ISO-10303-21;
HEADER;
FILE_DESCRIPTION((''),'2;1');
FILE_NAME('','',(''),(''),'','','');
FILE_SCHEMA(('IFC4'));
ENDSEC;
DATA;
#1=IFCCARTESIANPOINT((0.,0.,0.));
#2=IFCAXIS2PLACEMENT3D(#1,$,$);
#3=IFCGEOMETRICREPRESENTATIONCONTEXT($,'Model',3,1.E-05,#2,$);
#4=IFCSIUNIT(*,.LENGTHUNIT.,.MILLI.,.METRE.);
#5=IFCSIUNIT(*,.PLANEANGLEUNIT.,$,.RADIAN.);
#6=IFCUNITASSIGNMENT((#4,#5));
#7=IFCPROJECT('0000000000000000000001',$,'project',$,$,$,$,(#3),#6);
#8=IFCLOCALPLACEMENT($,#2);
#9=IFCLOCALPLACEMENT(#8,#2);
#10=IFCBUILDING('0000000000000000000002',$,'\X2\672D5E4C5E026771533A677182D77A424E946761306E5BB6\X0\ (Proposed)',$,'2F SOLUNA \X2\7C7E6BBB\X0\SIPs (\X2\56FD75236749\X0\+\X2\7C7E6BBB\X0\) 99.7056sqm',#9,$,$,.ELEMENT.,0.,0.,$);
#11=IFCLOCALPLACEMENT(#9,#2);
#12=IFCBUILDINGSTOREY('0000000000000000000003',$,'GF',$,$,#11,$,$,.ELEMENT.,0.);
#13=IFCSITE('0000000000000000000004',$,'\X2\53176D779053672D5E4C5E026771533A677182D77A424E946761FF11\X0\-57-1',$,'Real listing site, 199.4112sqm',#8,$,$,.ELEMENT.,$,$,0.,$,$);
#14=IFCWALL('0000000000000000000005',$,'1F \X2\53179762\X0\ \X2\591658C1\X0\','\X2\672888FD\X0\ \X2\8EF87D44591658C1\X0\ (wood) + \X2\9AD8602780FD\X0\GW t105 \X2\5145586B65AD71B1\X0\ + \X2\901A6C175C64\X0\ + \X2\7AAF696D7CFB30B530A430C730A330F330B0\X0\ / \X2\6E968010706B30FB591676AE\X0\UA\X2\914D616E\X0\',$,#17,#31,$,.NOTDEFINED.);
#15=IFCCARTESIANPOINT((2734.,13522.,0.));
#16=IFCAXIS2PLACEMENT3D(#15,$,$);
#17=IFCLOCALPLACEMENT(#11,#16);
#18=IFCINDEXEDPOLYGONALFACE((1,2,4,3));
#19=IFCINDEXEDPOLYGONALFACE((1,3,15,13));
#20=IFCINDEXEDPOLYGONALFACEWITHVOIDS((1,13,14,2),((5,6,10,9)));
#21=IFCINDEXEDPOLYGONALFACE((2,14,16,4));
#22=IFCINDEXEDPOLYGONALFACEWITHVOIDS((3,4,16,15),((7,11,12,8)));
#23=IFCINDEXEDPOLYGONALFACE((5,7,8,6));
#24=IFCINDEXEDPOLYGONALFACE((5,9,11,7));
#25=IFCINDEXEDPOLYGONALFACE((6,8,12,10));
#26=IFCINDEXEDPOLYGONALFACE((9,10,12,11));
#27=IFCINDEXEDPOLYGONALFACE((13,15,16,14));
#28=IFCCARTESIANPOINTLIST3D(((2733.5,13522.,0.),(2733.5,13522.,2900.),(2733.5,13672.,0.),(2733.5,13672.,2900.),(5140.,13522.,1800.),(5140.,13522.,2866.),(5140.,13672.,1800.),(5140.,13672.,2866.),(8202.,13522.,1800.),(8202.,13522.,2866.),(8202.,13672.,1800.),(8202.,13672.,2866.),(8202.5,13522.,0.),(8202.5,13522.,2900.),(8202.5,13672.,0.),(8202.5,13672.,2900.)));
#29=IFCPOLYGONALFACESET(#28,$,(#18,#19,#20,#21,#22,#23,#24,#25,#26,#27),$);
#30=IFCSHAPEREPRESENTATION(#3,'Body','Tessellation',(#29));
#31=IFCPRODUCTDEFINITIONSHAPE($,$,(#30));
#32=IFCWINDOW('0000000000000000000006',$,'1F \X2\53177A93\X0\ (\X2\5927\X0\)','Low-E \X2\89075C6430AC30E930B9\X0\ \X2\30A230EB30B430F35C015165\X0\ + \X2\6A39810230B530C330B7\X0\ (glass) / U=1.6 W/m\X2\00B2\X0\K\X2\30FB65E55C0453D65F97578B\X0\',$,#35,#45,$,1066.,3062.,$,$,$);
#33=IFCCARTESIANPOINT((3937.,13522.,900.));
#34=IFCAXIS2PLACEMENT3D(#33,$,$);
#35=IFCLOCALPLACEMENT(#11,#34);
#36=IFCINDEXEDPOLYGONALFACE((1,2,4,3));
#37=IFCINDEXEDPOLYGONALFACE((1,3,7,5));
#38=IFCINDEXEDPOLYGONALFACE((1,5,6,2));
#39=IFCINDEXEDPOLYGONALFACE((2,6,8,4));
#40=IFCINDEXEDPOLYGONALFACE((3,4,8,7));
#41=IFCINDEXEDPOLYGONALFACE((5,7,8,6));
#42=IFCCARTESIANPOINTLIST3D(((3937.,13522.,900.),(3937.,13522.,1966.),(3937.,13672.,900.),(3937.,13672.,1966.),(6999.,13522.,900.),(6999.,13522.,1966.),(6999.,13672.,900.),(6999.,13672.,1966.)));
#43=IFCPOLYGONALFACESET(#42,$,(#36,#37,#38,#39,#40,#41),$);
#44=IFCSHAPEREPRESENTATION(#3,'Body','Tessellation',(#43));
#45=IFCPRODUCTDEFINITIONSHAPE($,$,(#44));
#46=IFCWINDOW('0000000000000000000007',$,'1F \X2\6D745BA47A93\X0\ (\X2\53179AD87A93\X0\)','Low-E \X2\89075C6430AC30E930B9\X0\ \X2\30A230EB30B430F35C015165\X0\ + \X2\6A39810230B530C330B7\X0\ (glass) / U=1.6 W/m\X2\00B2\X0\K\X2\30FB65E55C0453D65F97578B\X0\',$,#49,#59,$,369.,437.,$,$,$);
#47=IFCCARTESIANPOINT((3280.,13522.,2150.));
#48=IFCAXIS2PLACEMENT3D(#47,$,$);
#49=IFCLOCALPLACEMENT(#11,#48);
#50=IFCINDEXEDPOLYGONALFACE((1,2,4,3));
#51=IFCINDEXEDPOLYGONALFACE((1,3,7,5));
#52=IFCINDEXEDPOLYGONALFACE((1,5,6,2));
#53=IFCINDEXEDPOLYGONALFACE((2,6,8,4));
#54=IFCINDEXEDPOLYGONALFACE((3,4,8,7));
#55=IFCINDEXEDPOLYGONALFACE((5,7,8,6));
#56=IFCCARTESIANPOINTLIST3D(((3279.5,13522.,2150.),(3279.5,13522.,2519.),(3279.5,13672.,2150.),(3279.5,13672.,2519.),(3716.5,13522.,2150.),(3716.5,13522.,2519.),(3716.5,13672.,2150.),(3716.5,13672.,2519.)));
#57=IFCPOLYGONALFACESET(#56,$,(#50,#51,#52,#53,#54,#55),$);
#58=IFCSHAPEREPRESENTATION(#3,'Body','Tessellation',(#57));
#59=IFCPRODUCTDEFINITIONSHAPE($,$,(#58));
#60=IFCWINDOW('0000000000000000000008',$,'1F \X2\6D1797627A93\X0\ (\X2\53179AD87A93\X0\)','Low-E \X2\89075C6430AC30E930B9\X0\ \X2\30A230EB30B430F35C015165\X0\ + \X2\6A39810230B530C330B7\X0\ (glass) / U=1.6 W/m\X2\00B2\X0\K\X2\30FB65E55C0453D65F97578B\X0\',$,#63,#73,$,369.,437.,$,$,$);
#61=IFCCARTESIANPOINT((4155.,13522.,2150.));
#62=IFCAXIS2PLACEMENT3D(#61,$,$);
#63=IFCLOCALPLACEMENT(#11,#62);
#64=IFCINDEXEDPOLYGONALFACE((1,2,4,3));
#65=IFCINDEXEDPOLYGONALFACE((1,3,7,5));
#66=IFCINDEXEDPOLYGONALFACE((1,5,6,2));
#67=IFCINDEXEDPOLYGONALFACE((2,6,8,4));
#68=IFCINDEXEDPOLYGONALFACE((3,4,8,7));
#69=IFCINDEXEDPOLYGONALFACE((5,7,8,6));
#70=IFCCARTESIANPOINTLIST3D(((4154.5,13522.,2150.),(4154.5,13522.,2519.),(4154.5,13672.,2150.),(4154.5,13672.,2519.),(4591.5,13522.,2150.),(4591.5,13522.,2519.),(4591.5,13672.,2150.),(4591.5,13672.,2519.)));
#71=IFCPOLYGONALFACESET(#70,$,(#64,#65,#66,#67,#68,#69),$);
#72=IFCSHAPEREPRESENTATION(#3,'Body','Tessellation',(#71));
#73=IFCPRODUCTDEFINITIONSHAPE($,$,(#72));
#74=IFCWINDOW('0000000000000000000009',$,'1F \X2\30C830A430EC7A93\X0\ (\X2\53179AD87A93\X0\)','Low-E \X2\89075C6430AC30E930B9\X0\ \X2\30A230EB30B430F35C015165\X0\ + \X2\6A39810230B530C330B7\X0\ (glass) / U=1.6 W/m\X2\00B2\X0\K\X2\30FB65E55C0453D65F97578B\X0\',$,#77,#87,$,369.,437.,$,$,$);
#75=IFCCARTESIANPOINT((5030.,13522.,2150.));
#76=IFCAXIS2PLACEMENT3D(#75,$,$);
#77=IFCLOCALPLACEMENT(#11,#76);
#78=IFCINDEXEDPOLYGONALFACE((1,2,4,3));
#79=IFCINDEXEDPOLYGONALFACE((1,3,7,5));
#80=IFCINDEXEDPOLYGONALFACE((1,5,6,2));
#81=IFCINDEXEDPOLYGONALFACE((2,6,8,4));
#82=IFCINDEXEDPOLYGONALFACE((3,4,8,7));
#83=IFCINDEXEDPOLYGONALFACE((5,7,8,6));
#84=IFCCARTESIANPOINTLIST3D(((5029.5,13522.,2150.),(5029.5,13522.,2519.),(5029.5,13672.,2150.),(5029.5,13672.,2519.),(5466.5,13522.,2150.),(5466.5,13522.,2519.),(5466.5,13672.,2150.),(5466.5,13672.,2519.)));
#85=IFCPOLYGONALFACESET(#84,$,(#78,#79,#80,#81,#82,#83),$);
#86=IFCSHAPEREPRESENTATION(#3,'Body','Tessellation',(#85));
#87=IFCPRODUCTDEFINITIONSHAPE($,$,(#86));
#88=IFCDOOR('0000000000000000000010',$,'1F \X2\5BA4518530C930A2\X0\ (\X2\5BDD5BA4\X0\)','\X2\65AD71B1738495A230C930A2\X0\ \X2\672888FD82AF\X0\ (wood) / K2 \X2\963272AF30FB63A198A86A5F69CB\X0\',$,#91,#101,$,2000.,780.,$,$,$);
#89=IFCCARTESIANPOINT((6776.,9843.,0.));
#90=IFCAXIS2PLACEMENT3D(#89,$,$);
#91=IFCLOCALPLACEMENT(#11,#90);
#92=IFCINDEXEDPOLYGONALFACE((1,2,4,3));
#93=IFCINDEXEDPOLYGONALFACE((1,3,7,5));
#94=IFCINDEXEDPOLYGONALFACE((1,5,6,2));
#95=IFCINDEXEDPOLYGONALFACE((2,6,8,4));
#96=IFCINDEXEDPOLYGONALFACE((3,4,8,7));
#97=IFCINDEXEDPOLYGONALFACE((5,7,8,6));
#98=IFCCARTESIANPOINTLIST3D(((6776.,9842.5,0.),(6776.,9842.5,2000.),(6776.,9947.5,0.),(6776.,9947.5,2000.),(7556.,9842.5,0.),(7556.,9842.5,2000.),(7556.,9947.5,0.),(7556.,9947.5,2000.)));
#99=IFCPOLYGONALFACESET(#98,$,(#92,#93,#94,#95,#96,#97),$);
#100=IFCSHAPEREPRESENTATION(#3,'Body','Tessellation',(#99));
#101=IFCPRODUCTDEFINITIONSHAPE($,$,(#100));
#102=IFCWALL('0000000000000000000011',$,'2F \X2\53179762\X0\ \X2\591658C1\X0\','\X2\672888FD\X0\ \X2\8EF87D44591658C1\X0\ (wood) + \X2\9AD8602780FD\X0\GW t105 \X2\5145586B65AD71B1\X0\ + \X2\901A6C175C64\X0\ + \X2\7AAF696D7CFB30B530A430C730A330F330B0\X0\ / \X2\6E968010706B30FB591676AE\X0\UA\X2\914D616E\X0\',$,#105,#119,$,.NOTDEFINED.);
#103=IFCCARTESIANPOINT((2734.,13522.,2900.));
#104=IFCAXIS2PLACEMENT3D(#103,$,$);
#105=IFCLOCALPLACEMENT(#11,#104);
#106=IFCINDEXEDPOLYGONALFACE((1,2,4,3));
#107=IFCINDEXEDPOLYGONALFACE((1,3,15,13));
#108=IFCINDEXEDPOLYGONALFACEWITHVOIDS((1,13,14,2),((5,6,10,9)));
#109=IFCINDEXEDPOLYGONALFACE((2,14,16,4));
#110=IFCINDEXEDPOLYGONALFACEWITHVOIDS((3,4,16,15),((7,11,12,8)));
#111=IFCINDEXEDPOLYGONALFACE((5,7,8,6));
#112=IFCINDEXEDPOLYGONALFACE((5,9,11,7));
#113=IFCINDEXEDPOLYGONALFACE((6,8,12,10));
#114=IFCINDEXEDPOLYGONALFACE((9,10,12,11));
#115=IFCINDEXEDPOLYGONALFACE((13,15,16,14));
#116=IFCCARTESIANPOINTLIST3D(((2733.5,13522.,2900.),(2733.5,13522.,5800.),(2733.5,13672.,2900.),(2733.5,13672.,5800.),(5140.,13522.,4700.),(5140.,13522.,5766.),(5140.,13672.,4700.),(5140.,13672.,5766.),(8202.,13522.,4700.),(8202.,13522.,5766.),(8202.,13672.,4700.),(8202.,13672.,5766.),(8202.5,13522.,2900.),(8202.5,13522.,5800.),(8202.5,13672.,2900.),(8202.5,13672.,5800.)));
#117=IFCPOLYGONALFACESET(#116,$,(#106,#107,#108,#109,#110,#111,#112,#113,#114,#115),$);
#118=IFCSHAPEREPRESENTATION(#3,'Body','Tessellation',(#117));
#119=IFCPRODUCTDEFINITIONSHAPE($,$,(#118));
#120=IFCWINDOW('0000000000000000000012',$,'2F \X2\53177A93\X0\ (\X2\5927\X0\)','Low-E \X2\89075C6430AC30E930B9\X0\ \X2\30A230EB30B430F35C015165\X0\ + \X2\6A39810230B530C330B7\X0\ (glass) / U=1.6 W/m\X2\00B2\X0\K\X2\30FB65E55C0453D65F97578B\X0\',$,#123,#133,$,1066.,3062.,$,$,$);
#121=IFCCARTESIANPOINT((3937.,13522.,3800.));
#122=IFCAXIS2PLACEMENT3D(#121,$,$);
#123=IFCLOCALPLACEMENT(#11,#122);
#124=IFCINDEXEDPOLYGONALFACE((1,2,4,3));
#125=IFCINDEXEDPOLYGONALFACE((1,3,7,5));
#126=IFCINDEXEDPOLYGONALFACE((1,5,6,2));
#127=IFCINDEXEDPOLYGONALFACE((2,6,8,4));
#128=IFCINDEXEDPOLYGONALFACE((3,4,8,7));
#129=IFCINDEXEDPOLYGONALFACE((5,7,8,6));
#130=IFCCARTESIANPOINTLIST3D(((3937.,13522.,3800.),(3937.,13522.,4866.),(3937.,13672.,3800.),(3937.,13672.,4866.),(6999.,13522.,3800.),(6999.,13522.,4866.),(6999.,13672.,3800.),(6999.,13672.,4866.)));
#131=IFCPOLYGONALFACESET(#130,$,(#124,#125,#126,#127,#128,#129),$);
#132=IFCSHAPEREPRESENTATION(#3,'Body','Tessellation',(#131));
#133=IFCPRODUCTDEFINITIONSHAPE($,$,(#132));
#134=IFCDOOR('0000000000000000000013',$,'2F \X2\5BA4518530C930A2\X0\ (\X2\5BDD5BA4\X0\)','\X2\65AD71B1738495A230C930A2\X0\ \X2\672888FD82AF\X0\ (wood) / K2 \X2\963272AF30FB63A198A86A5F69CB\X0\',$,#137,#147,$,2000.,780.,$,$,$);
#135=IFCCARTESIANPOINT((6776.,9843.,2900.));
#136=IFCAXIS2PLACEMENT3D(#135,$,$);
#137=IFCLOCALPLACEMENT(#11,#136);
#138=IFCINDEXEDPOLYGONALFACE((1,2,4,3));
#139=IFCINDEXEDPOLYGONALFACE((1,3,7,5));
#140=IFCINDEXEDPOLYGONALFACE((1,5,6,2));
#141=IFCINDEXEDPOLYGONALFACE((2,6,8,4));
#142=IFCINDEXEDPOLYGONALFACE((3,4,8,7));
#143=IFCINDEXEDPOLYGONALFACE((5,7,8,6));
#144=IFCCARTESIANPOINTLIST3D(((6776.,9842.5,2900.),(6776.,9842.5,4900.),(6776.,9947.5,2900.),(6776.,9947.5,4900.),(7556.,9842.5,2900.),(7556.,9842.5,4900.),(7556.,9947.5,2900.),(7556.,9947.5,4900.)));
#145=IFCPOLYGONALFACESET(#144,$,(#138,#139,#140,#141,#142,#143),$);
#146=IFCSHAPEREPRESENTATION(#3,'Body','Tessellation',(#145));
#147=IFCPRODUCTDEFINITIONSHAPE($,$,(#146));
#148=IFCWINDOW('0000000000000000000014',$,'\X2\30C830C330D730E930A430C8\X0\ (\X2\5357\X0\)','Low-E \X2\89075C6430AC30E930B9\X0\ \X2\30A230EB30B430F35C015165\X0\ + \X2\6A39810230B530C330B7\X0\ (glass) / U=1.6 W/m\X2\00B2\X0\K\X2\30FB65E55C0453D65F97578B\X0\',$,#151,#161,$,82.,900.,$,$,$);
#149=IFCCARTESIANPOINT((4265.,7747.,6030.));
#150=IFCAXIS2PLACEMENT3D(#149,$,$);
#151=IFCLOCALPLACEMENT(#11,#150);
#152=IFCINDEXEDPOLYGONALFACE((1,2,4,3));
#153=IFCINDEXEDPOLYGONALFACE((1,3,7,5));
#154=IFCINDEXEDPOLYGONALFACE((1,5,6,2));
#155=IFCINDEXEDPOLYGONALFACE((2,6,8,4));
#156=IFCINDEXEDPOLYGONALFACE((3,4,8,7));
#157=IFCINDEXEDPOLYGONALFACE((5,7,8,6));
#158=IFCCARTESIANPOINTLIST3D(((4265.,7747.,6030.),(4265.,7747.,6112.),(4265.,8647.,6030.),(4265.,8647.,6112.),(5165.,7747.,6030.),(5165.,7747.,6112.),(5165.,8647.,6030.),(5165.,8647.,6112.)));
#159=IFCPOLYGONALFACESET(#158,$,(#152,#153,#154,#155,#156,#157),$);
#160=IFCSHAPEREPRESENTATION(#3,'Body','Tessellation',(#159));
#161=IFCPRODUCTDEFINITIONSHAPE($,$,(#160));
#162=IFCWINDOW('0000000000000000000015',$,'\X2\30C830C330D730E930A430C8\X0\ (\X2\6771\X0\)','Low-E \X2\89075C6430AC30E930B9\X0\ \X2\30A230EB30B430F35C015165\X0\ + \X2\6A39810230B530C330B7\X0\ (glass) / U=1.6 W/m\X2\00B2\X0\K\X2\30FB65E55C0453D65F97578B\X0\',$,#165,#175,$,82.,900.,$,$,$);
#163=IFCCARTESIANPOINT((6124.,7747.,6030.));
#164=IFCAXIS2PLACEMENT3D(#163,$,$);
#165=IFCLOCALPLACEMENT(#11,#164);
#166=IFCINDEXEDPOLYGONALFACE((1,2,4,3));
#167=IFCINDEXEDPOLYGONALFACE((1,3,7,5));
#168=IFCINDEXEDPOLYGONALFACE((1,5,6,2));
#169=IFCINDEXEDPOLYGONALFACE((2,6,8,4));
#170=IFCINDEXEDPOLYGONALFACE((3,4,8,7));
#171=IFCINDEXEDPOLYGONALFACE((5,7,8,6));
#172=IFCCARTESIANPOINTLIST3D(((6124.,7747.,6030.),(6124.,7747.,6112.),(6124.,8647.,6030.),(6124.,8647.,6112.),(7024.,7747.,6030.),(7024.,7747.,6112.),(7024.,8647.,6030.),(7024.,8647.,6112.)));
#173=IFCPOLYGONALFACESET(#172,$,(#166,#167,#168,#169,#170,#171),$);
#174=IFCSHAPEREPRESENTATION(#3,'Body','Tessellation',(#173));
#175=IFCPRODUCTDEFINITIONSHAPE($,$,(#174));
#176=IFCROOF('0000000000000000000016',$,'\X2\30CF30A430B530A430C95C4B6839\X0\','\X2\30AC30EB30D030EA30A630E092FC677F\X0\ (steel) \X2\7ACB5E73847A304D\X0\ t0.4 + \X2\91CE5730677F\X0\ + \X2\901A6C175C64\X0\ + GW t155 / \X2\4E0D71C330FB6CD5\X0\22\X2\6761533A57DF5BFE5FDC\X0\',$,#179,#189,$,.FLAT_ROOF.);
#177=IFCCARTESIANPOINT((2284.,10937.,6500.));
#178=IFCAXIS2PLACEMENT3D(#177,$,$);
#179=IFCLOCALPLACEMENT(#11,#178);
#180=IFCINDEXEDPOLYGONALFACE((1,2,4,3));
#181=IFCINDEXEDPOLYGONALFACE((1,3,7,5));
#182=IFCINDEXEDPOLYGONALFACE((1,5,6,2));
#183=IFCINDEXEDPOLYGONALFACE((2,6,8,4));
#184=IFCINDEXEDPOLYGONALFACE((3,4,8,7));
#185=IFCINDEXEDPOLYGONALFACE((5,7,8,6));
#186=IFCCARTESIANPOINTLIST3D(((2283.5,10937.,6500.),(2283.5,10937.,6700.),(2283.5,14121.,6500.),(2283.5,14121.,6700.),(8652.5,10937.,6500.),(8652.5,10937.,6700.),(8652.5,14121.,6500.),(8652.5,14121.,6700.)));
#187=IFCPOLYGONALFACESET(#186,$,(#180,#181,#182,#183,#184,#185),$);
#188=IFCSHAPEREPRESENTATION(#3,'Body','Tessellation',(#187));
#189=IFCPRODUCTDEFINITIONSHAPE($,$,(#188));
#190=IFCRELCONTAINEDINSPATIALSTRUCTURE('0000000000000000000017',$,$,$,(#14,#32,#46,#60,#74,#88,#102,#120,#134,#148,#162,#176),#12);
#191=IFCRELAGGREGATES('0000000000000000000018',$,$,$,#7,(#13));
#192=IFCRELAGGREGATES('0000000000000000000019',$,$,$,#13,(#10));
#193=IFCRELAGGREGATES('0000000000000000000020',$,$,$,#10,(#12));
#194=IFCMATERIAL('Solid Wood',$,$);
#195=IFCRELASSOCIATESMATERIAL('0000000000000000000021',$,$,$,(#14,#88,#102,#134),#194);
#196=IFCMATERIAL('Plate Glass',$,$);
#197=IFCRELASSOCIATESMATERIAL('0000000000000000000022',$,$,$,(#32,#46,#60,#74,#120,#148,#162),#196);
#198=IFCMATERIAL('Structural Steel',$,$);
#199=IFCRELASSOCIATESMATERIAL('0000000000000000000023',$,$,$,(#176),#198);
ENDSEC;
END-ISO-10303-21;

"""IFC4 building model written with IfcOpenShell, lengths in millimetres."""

from ifc_helpers import new_model, si_unit, frame, frame_2d, origin, place, context, project, spatial, rectangle, extrude, material, element, fill, save


model = new_model("IFC4")

# Units and contexts
model_context = context("Model", 3, precision=1e-05, world=origin())
ifc_project = project(units=[si_unit("LENGTHUNIT", "METRE", prefix="MILLI"), si_unit("PLANEANGLEUNIT", "RADIAN")], contexts=[model_context])

# Site, building, storey
site_placement = place(None, origin())
site = spatial("IfcSite", under=ifc_project, at=site_placement, Name="北海道札幌市東区東苗穂五条１-57-1", ObjectType="Real listing site, 199.4112sqm", CompositionType="ELEMENT", RefElevation=0.0)
building_placement = place(site_placement, origin())
building = spatial("IfcBuilding", under=site, at=building_placement, Name="札幌市東区東苗穂五条の家 (Proposed)", ObjectType="2F SOLUNA 籾殻SIPs (国産杉+籾殻) 99.7056sqm", CompositionType="ELEMENT", ElevationOfRefHeight=0.0, ElevationOfTerrain=0.0)
storey_placement = place(building_placement, origin())
storey = spatial("IfcBuildingStorey", under=building, at=storey_placement, Name="GF", CompositionType="ELEMENT", Elevation=0.0)

# Wall, openings, windows
ifc_material_1 = material(Name="Solid Wood")
wall_1_placement = place(storey_placement, frame((2734.0, 13522.0, 0.0)))
wall_1 = element("IfcWall", 1, at=wall_1_placement, inside=storey, material=ifc_material_1, Name="1F 北面 外壁", Description="木製 軸組外壁 (wood) + 高性能GW t105 充填断熱 + 通気層 + 窯業系サイディング / 準耐火・外皮UA配慮", PredefinedType="NOTDEFINED", context=model_context, shape_type="SweptSolid", body=[
    extrude(rectangle(XDim=5469.0, YDim=150.0, at=frame_2d((2734.0, 75.0))), frame((2734.0, 13522.0, 0.0)), (0.0, 0.0, 1.0), 2900.0),
])
opening_1_placement = place(storey_placement, frame((3937.0, 13522.0, 900.0)))
opening_1 = element("IfcOpeningElement", 2, at=opening_1_placement, cuts=wall_1, PredefinedType="NOTDEFINED", context=model_context, shape_type="SweptSolid", body=[
    extrude(rectangle(XDim=3062.0, YDim=150.0, at=frame_2d((1531.0, 75.0))), frame((3937.0, 13522.0, 900.0)), (0.0, 0.0, 1.0), 1066.0),
])
opening_2_placement = place(storey_placement, frame((3280.0, 13522.0, 2150.0)))
opening_2 = element("IfcOpeningElement", 3, at=opening_2_placement, cuts=wall_1, PredefinedType="NOTDEFINED", context=model_context, shape_type="SweptSolid", body=[
    extrude(rectangle(XDim=437.0, YDim=150.0, at=frame_2d((218.0, 75.0))), frame((3280.0, 13522.0, 2150.0)), (0.0, 0.0, 1.0), 369.0),
])
opening_3_placement = place(storey_placement, frame((4155.0, 13522.0, 2150.0)))
opening_3 = element("IfcOpeningElement", 4, at=opening_3_placement, cuts=wall_1, PredefinedType="NOTDEFINED", context=model_context, shape_type="SweptSolid", body=[
    extrude(rectangle(XDim=437.0, YDim=150.0, at=frame_2d((218.0, 75.0))), frame((4155.0, 13522.0, 2150.0)), (0.0, 0.0, 1.0), 369.0),
])
opening_4_placement = place(storey_placement, frame((5030.0, 13522.0, 2150.0)))
opening_4 = element("IfcOpeningElement", 5, at=opening_4_placement, cuts=wall_1, PredefinedType="NOTDEFINED", context=model_context, shape_type="SweptSolid", body=[
    extrude(rectangle(XDim=437.0, YDim=150.0, at=frame_2d((218.0, 75.0))), frame((5030.0, 13522.0, 2150.0)), (0.0, 0.0, 1.0), 369.0),
])
ifc_material_2 = material(Name="Plate Glass")
window_1_placement = place(storey_placement, frame((3937.0, 13522.0, 900.0)))
window_1 = element("IfcWindow", 6, at=window_1_placement, inside=storey, material=ifc_material_2, Name="1F 北窓 (大)", Description="Low-E 複層ガラス アルゴン封入 + 樹脂サッシ (glass) / U=1.6 W/m²K・日射取得型", OverallHeight=1066.0, OverallWidth=3062.0, context=model_context, shape_type="SweptSolid", body=[
    extrude(rectangle(XDim=3062.0, YDim=150.0, at=frame_2d((1531.0, 75.0))), frame((3937.0, 13522.0, 900.0)), (0.0, 0.0, 1.0), 1066.0),
])
fill(opening_1, window_1)
window_2_placement = place(storey_placement, frame((3280.0, 13522.0, 2150.0)))
window_2 = element("IfcWindow", 7, at=window_2_placement, inside=storey, material=ifc_material_2, Name="1F 浴室窓 (北高窓)", Description="Low-E 複層ガラス アルゴン封入 + 樹脂サッシ (glass) / U=1.6 W/m²K・日射取得型", OverallHeight=369.0, OverallWidth=437.0, context=model_context, shape_type="SweptSolid", body=[
    extrude(rectangle(XDim=437.0, YDim=150.0, at=frame_2d((218.0, 75.0))), frame((3280.0, 13522.0, 2150.0)), (0.0, 0.0, 1.0), 369.0),
])
fill(opening_2, window_2)
window_3_placement = place(storey_placement, frame((4155.0, 13522.0, 2150.0)))
window_3 = element("IfcWindow", 8, at=window_3_placement, inside=storey, material=ifc_material_2, Name="1F 洗面窓 (北高窓)", Description="Low-E 複層ガラス アルゴン封入 + 樹脂サッシ (glass) / U=1.6 W/m²K・日射取得型", OverallHeight=369.0, OverallWidth=437.0, context=model_context, shape_type="SweptSolid", body=[
    extrude(rectangle(XDim=437.0, YDim=150.0, at=frame_2d((218.0, 75.0))), frame((4155.0, 13522.0, 2150.0)), (0.0, 0.0, 1.0), 369.0),
])
fill(opening_3, window_3)
window_4_placement = place(storey_placement, frame((5030.0, 13522.0, 2150.0)))
window_4 = element("IfcWindow", 9, at=window_4_placement, inside=storey, material=ifc_material_2, Name="1F トイレ窓 (北高窓)", Description="Low-E 複層ガラス アルゴン封入 + 樹脂サッシ (glass) / U=1.6 W/m²K・日射取得型", OverallHeight=369.0, OverallWidth=437.0, context=model_context, shape_type="SweptSolid", body=[
    extrude(rectangle(XDim=437.0, YDim=150.0, at=frame_2d((218.0, 75.0))), frame((5030.0, 13522.0, 2150.0)), (0.0, 0.0, 1.0), 369.0),
])
fill(opening_4, window_4)

# Door
door_1_placement = place(storey_placement, frame((6776.0, 9843.0, 0.0)))
element("IfcDoor", 10, at=door_1_placement, inside=storey, material=ifc_material_1, Name="1F 室内ドア (寝室)", Description="断熱玄関ドア 木製芯 (wood) / K2 防犯・採風機構", OverallHeight=2000.0, OverallWidth=780.0, context=model_context, shape_type="SweptSolid", body=[
    extrude(rectangle(XDim=780.0, YDim=105.0, at=frame_2d((390.0, 52.0))), frame((6776.0, 9843.0, 0.0)), (0.0, 0.0, 1.0), 2000.0),
])

# Wall, opening, window
wall_2_placement = place(storey_placement, frame((2734.0, 13522.0, 2900.0)))
wall_2 = element("IfcWall", 11, at=wall_2_placement, inside=storey, material=ifc_material_1, Name="2F 北面 外壁", Description="木製 軸組外壁 (wood) + 高性能GW t105 充填断熱 + 通気層 + 窯業系サイディング / 準耐火・外皮UA配慮", PredefinedType="NOTDEFINED", context=model_context, shape_type="SweptSolid", body=[
    extrude(rectangle(XDim=5469.0, YDim=150.0, at=frame_2d((2734.0, 75.0))), frame((2734.0, 13522.0, 2900.0)), (0.0, 0.0, 1.0), 2900.0),
])
opening_5_placement = place(storey_placement, frame((3937.0, 13522.0, 3800.0)))
opening_5 = element("IfcOpeningElement", 12, at=opening_5_placement, cuts=wall_2, PredefinedType="NOTDEFINED", context=model_context, shape_type="SweptSolid", body=[
    extrude(rectangle(XDim=3062.0, YDim=150.0, at=frame_2d((1531.0, 75.0))), frame((3937.0, 13522.0, 3800.0)), (0.0, 0.0, 1.0), 1066.0),
])
window_5_placement = place(storey_placement, frame((3937.0, 13522.0, 3800.0)))
window_5 = element("IfcWindow", 13, at=window_5_placement, inside=storey, material=ifc_material_2, Name="2F 北窓 (大)", Description="Low-E 複層ガラス アルゴン封入 + 樹脂サッシ (glass) / U=1.6 W/m²K・日射取得型", OverallHeight=1066.0, OverallWidth=3062.0, context=model_context, shape_type="SweptSolid", body=[
    extrude(rectangle(XDim=3062.0, YDim=150.0, at=frame_2d((1531.0, 75.0))), frame((3937.0, 13522.0, 3800.0)), (0.0, 0.0, 1.0), 1066.0),
])
fill(opening_5, window_5)

# Door
door_2_placement = place(storey_placement, frame((6776.0, 9843.0, 2900.0)))
element("IfcDoor", 14, at=door_2_placement, inside=storey, material=ifc_material_1, Name="2F 室内ドア (寝室)", Description="断熱玄関ドア 木製芯 (wood) / K2 防犯・採風機構", OverallHeight=2000.0, OverallWidth=780.0, context=model_context, shape_type="SweptSolid", body=[
    extrude(rectangle(XDim=780.0, YDim=105.0, at=frame_2d((390.0, 52.0))), frame((6776.0, 9843.0, 2900.0)), (0.0, 0.0, 1.0), 2000.0),
])

# Windows
window_6_placement = place(storey_placement, frame((4265.0, 7747.0, 6030.0)))
element("IfcWindow", 15, at=window_6_placement, inside=storey, material=ifc_material_2, Name="トップライト (南)", Description="Low-E 複層ガラス アルゴン封入 + 樹脂サッシ (glass) / U=1.6 W/m²K・日射取得型", OverallHeight=82.0, OverallWidth=900.0, context=model_context, shape_type="SweptSolid", body=[
    extrude(rectangle(XDim=900.0, YDim=900.0, at=frame_2d((450.0, 450.0))), frame((4265.0, 7747.0, 6030.0)), (0.0, 0.0, 1.0), 82.0),
])
window_7_placement = place(storey_placement, frame((6124.0, 7747.0, 6030.0)))
element("IfcWindow", 16, at=window_7_placement, inside=storey, material=ifc_material_2, Name="トップライト (東)", Description="Low-E 複層ガラス アルゴン封入 + 樹脂サッシ (glass) / U=1.6 W/m²K・日射取得型", OverallHeight=82.0, OverallWidth=900.0, context=model_context, shape_type="SweptSolid", body=[
    extrude(rectangle(XDim=900.0, YDim=900.0, at=frame_2d((450.0, 450.0))), frame((6124.0, 7747.0, 6030.0)), (0.0, 0.0, 1.0), 82.0),
])

# Roof
ifc_material_3 = material(Name="Structural Steel")
roof_placement = place(storey_placement, frame((2284.0, 10937.0, 6500.0)))
element("IfcRoof", 17, at=roof_placement, inside=storey, material=ifc_material_3, Name="ハイサイド屋根", Description="ガルバリウム鋼板 (steel) 立平葺き t0.4 + 野地板 + 通気層 + GW t155 / 不燃・法22条区域対応", PredefinedType="FLAT_ROOF", context=model_context, shape_type="SweptSolid", body=[
    extrude(rectangle(XDim=6369.0, YDim=3184.0, at=frame_2d((3184.0, 1592.0))), frame((2284.0, 10937.0, 6500.0)), (0.0, 0.0, 1.0), 200.0),
])

save(model, "model.ifc")
